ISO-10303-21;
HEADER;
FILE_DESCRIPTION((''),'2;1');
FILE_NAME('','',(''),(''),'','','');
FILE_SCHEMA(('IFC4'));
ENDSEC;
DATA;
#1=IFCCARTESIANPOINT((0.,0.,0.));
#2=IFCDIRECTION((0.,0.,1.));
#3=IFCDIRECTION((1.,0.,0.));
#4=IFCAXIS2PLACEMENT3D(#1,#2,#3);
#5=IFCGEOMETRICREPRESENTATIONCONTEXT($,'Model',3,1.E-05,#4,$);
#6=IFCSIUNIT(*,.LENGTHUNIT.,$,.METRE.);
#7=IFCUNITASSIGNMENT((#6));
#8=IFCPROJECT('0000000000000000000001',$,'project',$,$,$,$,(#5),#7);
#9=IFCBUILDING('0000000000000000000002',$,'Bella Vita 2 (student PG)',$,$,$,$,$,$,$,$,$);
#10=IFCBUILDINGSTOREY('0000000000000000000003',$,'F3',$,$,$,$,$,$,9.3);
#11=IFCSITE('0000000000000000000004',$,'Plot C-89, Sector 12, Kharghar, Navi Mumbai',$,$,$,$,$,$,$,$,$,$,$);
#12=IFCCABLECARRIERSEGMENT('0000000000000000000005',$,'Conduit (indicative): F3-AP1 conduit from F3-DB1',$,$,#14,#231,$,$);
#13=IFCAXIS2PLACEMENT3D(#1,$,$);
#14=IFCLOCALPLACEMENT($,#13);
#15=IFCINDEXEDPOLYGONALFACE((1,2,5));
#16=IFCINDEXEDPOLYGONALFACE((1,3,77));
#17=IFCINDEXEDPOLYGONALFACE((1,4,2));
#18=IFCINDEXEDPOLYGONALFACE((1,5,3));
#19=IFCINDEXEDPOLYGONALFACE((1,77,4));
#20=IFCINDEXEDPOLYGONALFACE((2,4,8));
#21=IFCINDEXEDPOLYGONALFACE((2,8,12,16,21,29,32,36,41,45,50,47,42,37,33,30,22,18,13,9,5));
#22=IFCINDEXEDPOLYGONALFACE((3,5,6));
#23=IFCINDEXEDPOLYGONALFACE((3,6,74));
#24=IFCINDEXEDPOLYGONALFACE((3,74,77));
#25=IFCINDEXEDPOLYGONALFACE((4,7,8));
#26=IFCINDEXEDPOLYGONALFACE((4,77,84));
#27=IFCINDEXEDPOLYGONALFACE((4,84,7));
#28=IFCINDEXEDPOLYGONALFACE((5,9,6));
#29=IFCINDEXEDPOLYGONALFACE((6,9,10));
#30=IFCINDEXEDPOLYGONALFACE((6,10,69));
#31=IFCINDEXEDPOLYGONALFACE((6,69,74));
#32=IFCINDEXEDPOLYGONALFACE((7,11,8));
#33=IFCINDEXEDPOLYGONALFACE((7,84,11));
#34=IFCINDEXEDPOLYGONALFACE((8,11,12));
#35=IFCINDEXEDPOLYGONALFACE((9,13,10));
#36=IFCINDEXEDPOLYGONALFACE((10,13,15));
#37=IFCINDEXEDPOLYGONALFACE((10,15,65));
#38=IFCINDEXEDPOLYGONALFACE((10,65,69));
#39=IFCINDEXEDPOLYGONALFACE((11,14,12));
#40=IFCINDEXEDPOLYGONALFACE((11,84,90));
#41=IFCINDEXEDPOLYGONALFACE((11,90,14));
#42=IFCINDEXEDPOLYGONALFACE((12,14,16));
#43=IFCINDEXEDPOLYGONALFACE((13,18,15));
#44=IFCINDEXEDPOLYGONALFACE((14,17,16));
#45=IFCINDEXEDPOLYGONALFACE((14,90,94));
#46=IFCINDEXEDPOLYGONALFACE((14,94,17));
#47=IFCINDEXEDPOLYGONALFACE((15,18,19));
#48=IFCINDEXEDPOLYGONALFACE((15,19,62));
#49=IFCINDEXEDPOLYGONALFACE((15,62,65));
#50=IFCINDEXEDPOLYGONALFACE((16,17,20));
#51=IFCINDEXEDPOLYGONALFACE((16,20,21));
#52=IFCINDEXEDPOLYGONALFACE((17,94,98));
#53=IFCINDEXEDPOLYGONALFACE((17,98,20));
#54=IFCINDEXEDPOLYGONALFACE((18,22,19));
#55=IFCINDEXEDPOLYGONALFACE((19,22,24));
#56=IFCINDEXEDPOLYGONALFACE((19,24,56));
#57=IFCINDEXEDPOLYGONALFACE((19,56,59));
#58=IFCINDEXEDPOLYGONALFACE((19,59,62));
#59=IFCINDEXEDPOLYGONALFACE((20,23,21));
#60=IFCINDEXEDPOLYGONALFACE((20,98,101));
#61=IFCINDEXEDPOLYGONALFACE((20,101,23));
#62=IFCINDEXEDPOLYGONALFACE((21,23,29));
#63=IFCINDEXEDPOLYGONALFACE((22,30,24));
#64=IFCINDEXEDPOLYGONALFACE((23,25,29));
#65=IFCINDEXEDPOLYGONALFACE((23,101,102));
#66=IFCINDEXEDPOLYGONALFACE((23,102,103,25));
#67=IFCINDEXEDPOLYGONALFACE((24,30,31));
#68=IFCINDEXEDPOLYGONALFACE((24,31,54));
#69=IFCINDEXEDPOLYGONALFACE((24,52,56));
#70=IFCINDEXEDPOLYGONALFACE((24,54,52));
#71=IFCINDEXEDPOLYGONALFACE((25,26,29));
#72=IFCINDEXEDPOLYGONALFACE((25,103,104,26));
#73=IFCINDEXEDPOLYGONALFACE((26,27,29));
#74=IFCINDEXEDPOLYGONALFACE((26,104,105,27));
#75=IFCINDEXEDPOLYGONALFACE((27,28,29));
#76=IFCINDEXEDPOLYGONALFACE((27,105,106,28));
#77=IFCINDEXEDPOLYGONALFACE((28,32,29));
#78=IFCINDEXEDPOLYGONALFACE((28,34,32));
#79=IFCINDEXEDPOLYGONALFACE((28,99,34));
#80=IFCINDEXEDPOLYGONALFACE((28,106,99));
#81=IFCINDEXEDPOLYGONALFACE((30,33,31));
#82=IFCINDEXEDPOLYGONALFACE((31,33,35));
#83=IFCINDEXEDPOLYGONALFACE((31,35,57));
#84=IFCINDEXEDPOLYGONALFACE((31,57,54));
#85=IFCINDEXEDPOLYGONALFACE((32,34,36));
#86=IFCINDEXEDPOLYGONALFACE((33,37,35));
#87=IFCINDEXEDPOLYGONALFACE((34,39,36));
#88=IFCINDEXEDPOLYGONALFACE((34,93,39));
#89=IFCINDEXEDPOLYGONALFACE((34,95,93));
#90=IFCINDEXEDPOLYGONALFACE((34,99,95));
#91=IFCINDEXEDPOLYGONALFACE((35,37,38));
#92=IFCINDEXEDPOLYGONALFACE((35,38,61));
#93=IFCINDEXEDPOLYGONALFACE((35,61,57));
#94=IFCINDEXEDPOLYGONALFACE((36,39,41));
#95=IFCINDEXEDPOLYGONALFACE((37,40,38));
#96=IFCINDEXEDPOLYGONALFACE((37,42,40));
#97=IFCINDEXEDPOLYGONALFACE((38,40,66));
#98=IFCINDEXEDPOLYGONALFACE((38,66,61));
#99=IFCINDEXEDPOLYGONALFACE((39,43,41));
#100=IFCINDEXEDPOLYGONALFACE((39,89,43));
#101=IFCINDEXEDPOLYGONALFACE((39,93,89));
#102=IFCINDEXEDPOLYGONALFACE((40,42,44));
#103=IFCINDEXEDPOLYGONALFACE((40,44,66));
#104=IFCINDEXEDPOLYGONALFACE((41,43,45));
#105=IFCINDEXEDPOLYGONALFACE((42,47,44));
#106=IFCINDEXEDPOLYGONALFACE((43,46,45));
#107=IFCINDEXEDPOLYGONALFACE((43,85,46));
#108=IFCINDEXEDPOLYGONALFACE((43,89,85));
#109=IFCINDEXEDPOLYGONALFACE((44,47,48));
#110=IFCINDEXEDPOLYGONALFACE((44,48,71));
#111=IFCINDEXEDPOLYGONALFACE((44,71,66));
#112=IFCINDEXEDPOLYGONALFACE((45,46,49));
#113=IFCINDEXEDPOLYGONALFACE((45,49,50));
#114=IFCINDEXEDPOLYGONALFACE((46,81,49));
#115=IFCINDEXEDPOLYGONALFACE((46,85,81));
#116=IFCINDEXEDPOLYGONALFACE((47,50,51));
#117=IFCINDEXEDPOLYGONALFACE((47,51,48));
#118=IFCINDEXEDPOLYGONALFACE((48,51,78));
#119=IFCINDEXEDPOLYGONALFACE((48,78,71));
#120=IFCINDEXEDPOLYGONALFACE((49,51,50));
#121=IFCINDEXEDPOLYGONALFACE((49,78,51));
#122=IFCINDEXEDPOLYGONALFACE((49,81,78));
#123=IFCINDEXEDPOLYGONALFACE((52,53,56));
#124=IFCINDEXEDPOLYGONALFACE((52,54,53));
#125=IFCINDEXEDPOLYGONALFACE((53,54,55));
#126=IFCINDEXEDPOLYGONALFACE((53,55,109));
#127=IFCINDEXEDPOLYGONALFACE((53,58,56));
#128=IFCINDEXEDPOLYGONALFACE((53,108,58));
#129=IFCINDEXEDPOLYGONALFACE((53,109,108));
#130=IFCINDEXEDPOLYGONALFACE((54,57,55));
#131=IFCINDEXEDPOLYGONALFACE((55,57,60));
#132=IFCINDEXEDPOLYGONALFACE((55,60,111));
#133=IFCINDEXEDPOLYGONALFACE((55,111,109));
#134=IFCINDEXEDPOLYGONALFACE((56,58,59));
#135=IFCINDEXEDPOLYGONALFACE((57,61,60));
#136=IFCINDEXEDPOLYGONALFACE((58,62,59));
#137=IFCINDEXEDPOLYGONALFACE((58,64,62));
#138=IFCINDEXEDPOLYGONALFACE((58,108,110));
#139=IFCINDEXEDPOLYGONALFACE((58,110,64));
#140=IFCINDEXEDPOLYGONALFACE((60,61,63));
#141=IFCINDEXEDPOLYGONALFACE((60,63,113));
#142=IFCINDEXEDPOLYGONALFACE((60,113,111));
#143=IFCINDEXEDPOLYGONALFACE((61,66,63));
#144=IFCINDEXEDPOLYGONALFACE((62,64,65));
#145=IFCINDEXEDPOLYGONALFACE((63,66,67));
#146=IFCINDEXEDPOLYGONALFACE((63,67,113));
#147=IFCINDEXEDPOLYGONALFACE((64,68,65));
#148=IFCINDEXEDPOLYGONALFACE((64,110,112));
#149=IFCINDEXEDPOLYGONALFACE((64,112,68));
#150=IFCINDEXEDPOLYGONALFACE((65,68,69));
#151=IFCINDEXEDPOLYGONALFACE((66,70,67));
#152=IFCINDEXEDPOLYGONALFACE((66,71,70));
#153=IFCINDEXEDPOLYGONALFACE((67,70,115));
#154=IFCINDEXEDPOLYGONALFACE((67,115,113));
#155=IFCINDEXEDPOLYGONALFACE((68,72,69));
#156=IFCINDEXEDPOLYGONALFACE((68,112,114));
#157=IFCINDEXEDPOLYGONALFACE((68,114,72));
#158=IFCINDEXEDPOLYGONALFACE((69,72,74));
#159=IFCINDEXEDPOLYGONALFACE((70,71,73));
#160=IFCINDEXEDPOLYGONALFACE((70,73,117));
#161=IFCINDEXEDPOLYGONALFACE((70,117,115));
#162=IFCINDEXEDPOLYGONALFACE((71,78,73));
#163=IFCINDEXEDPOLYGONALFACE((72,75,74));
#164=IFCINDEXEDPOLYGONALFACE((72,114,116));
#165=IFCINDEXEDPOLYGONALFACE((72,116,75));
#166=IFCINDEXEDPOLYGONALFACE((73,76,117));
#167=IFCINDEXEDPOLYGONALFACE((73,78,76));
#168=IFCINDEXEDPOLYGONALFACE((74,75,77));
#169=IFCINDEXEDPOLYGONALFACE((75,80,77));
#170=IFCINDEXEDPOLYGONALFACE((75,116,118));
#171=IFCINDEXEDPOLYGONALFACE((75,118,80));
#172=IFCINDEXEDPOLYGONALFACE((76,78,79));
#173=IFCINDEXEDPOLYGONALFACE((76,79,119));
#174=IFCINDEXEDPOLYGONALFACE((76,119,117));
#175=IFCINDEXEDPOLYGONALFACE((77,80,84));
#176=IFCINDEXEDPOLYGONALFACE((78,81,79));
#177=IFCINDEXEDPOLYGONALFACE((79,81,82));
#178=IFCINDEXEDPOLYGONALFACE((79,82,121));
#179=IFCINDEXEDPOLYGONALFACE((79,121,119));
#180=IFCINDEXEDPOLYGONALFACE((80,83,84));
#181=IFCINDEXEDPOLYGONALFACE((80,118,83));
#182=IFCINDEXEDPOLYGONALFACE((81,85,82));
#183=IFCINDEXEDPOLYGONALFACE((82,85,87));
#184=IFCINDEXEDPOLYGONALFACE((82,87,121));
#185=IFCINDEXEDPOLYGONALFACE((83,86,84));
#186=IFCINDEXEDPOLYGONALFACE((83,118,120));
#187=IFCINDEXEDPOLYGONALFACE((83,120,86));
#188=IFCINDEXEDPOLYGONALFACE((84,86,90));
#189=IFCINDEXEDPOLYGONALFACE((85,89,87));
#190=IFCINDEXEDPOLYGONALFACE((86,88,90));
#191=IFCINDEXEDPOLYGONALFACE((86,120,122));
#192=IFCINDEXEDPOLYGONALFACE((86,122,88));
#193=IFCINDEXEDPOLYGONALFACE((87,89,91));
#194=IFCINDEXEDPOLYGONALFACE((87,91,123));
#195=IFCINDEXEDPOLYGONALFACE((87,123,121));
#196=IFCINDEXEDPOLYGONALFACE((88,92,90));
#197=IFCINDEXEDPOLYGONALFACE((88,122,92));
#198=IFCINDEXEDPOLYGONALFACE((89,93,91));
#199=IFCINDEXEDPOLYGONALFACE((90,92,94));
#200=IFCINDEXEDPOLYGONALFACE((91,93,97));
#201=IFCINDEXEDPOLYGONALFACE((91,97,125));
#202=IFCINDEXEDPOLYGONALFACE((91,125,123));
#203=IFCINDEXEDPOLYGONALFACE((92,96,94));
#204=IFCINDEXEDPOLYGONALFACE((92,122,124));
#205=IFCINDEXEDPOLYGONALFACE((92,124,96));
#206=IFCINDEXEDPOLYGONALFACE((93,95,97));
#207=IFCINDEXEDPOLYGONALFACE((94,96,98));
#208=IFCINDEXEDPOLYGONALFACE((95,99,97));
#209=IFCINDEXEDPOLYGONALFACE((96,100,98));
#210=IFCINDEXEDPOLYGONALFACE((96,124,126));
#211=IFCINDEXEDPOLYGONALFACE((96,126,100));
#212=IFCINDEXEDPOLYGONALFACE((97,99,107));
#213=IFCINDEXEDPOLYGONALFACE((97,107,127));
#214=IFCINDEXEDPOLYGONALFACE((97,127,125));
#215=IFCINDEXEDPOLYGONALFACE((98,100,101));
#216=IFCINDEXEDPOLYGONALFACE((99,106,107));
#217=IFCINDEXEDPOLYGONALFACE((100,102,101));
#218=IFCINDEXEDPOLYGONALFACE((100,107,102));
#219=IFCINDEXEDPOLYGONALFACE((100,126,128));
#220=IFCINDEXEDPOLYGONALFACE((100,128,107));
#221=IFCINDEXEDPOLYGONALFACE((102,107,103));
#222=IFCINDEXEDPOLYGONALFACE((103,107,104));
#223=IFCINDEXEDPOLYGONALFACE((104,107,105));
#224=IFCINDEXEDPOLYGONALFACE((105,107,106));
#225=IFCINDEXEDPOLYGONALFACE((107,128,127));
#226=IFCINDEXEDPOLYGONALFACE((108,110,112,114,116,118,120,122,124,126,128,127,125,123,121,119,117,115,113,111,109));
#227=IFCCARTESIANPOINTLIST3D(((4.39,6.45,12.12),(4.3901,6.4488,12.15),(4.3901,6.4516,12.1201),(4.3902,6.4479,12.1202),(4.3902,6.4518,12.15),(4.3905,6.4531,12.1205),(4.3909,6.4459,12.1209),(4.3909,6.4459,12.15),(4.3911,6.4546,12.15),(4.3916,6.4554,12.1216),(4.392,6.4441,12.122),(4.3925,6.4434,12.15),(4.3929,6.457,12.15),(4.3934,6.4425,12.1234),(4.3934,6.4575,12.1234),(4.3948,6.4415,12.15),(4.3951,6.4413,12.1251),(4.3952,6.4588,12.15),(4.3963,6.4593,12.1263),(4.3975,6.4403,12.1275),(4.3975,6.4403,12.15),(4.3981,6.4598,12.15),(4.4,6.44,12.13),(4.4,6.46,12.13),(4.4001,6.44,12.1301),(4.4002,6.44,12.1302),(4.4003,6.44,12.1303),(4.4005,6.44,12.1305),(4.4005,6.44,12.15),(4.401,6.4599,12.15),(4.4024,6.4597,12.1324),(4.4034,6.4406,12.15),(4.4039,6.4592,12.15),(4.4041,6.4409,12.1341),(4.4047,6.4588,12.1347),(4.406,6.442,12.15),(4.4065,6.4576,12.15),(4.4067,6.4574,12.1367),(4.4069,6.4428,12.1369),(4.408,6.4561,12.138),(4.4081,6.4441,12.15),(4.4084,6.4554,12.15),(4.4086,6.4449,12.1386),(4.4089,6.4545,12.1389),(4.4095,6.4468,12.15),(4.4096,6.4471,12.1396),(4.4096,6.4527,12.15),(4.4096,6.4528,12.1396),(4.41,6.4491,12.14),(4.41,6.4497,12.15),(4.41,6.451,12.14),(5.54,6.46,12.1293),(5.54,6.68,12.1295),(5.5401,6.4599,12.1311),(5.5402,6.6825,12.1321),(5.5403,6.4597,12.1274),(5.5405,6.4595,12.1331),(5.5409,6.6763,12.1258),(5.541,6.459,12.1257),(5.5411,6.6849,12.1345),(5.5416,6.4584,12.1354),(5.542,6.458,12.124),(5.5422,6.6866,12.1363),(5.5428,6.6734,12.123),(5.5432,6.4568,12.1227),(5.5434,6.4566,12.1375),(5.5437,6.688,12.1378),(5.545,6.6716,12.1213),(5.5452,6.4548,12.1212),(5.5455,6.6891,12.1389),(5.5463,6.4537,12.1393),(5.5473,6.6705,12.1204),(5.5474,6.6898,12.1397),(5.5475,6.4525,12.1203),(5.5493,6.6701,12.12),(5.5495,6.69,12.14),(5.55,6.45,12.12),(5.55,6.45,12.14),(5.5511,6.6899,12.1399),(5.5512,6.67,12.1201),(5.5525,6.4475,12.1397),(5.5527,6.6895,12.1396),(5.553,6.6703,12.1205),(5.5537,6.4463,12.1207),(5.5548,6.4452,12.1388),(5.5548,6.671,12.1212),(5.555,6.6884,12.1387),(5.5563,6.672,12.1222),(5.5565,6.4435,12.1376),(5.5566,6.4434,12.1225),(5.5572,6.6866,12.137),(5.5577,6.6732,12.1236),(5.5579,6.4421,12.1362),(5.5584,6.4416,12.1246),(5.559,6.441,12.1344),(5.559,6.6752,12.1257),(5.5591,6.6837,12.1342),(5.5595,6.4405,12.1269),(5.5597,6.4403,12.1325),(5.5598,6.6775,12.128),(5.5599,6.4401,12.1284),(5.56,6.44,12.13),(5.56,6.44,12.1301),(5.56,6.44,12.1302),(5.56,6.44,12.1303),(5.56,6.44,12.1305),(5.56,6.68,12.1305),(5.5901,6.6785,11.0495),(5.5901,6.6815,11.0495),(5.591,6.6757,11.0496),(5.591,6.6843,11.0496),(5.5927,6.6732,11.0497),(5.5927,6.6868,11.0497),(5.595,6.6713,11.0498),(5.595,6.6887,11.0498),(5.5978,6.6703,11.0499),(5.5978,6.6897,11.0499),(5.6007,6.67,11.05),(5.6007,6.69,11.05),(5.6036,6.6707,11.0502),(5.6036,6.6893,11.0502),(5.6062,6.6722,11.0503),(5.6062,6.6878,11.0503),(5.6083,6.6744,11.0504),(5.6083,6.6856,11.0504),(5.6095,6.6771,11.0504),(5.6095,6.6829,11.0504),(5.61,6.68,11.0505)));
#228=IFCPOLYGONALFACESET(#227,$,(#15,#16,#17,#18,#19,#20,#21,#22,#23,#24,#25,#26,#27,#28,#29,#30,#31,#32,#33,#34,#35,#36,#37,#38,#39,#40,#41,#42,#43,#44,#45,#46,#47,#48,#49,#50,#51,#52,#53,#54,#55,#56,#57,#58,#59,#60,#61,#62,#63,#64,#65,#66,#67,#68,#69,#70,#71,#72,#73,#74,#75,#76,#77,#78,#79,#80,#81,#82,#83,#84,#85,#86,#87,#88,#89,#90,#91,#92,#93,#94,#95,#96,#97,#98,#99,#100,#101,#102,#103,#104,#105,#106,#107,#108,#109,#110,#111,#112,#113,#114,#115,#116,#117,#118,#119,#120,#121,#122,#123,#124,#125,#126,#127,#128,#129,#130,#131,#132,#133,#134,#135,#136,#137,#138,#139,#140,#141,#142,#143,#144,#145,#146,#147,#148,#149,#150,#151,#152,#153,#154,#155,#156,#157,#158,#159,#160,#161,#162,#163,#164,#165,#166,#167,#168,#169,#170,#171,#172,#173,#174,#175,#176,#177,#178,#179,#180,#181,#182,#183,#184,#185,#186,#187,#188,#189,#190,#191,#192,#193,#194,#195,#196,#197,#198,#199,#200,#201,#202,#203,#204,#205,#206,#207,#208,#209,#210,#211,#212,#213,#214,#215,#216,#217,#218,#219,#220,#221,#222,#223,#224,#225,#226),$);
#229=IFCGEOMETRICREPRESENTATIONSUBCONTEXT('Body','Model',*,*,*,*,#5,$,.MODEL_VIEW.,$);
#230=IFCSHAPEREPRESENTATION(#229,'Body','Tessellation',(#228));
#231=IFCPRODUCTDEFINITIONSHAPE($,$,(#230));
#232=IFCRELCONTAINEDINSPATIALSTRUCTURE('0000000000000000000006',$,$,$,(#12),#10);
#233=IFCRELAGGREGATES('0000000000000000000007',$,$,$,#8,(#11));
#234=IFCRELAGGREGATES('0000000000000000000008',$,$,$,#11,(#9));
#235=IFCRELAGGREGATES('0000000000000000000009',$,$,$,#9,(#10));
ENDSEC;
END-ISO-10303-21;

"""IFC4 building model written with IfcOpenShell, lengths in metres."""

from ifc_helpers import new_model, entity, si_unit, origin, origin_with_axes, place, context, subcontext, project, spatial, element, save


model = new_model("IFC4")

# Units and contexts
model_context = context("Model", 3, precision=1e-05, world=origin_with_axes())
body_context = subcontext(model_context, "Body", "Model", "MODEL_VIEW")
ifc_project = project(units=[si_unit("LENGTHUNIT", "METRE")], contexts=[model_context])

# Site, building, storey
site = spatial("IfcSite", under=ifc_project, Name="Plot C-89, Sector 12, Kharghar, Navi Mumbai")
building = spatial("IfcBuilding", under=site, Name="Bella Vita 2 (student PG)")
storey = spatial("IfcBuildingStorey", under=building, Name="F3", Elevation=9.3)

# Cable carrier segment
cable_carrier_segment_1_placement = place(None, origin())
element("IfcCableCarrierSegment", 1, at=cable_carrier_segment_1_placement, inside=storey, Name="Conduit (indicative): F3-AP1 conduit from F3-DB1", context=body_context, shape_type="AdvancedSweptSolid", body=[
    entity("IfcSweptDiskSolid", entity("IfcPolyline", [entity("IfcCartesianPoint", [5.6, 6.68, 11.05]), entity("IfcCartesianPoint", [5.55, 6.68, 12.13]), entity("IfcCartesianPoint", [5.55, 6.45, 12.13]), entity("IfcCartesianPoint", [4.4, 6.45, 12.13]), entity("IfcCartesianPoint", [4.4, 6.45, 12.15])]), 0.01),
])

save(model, "model.ifc")
